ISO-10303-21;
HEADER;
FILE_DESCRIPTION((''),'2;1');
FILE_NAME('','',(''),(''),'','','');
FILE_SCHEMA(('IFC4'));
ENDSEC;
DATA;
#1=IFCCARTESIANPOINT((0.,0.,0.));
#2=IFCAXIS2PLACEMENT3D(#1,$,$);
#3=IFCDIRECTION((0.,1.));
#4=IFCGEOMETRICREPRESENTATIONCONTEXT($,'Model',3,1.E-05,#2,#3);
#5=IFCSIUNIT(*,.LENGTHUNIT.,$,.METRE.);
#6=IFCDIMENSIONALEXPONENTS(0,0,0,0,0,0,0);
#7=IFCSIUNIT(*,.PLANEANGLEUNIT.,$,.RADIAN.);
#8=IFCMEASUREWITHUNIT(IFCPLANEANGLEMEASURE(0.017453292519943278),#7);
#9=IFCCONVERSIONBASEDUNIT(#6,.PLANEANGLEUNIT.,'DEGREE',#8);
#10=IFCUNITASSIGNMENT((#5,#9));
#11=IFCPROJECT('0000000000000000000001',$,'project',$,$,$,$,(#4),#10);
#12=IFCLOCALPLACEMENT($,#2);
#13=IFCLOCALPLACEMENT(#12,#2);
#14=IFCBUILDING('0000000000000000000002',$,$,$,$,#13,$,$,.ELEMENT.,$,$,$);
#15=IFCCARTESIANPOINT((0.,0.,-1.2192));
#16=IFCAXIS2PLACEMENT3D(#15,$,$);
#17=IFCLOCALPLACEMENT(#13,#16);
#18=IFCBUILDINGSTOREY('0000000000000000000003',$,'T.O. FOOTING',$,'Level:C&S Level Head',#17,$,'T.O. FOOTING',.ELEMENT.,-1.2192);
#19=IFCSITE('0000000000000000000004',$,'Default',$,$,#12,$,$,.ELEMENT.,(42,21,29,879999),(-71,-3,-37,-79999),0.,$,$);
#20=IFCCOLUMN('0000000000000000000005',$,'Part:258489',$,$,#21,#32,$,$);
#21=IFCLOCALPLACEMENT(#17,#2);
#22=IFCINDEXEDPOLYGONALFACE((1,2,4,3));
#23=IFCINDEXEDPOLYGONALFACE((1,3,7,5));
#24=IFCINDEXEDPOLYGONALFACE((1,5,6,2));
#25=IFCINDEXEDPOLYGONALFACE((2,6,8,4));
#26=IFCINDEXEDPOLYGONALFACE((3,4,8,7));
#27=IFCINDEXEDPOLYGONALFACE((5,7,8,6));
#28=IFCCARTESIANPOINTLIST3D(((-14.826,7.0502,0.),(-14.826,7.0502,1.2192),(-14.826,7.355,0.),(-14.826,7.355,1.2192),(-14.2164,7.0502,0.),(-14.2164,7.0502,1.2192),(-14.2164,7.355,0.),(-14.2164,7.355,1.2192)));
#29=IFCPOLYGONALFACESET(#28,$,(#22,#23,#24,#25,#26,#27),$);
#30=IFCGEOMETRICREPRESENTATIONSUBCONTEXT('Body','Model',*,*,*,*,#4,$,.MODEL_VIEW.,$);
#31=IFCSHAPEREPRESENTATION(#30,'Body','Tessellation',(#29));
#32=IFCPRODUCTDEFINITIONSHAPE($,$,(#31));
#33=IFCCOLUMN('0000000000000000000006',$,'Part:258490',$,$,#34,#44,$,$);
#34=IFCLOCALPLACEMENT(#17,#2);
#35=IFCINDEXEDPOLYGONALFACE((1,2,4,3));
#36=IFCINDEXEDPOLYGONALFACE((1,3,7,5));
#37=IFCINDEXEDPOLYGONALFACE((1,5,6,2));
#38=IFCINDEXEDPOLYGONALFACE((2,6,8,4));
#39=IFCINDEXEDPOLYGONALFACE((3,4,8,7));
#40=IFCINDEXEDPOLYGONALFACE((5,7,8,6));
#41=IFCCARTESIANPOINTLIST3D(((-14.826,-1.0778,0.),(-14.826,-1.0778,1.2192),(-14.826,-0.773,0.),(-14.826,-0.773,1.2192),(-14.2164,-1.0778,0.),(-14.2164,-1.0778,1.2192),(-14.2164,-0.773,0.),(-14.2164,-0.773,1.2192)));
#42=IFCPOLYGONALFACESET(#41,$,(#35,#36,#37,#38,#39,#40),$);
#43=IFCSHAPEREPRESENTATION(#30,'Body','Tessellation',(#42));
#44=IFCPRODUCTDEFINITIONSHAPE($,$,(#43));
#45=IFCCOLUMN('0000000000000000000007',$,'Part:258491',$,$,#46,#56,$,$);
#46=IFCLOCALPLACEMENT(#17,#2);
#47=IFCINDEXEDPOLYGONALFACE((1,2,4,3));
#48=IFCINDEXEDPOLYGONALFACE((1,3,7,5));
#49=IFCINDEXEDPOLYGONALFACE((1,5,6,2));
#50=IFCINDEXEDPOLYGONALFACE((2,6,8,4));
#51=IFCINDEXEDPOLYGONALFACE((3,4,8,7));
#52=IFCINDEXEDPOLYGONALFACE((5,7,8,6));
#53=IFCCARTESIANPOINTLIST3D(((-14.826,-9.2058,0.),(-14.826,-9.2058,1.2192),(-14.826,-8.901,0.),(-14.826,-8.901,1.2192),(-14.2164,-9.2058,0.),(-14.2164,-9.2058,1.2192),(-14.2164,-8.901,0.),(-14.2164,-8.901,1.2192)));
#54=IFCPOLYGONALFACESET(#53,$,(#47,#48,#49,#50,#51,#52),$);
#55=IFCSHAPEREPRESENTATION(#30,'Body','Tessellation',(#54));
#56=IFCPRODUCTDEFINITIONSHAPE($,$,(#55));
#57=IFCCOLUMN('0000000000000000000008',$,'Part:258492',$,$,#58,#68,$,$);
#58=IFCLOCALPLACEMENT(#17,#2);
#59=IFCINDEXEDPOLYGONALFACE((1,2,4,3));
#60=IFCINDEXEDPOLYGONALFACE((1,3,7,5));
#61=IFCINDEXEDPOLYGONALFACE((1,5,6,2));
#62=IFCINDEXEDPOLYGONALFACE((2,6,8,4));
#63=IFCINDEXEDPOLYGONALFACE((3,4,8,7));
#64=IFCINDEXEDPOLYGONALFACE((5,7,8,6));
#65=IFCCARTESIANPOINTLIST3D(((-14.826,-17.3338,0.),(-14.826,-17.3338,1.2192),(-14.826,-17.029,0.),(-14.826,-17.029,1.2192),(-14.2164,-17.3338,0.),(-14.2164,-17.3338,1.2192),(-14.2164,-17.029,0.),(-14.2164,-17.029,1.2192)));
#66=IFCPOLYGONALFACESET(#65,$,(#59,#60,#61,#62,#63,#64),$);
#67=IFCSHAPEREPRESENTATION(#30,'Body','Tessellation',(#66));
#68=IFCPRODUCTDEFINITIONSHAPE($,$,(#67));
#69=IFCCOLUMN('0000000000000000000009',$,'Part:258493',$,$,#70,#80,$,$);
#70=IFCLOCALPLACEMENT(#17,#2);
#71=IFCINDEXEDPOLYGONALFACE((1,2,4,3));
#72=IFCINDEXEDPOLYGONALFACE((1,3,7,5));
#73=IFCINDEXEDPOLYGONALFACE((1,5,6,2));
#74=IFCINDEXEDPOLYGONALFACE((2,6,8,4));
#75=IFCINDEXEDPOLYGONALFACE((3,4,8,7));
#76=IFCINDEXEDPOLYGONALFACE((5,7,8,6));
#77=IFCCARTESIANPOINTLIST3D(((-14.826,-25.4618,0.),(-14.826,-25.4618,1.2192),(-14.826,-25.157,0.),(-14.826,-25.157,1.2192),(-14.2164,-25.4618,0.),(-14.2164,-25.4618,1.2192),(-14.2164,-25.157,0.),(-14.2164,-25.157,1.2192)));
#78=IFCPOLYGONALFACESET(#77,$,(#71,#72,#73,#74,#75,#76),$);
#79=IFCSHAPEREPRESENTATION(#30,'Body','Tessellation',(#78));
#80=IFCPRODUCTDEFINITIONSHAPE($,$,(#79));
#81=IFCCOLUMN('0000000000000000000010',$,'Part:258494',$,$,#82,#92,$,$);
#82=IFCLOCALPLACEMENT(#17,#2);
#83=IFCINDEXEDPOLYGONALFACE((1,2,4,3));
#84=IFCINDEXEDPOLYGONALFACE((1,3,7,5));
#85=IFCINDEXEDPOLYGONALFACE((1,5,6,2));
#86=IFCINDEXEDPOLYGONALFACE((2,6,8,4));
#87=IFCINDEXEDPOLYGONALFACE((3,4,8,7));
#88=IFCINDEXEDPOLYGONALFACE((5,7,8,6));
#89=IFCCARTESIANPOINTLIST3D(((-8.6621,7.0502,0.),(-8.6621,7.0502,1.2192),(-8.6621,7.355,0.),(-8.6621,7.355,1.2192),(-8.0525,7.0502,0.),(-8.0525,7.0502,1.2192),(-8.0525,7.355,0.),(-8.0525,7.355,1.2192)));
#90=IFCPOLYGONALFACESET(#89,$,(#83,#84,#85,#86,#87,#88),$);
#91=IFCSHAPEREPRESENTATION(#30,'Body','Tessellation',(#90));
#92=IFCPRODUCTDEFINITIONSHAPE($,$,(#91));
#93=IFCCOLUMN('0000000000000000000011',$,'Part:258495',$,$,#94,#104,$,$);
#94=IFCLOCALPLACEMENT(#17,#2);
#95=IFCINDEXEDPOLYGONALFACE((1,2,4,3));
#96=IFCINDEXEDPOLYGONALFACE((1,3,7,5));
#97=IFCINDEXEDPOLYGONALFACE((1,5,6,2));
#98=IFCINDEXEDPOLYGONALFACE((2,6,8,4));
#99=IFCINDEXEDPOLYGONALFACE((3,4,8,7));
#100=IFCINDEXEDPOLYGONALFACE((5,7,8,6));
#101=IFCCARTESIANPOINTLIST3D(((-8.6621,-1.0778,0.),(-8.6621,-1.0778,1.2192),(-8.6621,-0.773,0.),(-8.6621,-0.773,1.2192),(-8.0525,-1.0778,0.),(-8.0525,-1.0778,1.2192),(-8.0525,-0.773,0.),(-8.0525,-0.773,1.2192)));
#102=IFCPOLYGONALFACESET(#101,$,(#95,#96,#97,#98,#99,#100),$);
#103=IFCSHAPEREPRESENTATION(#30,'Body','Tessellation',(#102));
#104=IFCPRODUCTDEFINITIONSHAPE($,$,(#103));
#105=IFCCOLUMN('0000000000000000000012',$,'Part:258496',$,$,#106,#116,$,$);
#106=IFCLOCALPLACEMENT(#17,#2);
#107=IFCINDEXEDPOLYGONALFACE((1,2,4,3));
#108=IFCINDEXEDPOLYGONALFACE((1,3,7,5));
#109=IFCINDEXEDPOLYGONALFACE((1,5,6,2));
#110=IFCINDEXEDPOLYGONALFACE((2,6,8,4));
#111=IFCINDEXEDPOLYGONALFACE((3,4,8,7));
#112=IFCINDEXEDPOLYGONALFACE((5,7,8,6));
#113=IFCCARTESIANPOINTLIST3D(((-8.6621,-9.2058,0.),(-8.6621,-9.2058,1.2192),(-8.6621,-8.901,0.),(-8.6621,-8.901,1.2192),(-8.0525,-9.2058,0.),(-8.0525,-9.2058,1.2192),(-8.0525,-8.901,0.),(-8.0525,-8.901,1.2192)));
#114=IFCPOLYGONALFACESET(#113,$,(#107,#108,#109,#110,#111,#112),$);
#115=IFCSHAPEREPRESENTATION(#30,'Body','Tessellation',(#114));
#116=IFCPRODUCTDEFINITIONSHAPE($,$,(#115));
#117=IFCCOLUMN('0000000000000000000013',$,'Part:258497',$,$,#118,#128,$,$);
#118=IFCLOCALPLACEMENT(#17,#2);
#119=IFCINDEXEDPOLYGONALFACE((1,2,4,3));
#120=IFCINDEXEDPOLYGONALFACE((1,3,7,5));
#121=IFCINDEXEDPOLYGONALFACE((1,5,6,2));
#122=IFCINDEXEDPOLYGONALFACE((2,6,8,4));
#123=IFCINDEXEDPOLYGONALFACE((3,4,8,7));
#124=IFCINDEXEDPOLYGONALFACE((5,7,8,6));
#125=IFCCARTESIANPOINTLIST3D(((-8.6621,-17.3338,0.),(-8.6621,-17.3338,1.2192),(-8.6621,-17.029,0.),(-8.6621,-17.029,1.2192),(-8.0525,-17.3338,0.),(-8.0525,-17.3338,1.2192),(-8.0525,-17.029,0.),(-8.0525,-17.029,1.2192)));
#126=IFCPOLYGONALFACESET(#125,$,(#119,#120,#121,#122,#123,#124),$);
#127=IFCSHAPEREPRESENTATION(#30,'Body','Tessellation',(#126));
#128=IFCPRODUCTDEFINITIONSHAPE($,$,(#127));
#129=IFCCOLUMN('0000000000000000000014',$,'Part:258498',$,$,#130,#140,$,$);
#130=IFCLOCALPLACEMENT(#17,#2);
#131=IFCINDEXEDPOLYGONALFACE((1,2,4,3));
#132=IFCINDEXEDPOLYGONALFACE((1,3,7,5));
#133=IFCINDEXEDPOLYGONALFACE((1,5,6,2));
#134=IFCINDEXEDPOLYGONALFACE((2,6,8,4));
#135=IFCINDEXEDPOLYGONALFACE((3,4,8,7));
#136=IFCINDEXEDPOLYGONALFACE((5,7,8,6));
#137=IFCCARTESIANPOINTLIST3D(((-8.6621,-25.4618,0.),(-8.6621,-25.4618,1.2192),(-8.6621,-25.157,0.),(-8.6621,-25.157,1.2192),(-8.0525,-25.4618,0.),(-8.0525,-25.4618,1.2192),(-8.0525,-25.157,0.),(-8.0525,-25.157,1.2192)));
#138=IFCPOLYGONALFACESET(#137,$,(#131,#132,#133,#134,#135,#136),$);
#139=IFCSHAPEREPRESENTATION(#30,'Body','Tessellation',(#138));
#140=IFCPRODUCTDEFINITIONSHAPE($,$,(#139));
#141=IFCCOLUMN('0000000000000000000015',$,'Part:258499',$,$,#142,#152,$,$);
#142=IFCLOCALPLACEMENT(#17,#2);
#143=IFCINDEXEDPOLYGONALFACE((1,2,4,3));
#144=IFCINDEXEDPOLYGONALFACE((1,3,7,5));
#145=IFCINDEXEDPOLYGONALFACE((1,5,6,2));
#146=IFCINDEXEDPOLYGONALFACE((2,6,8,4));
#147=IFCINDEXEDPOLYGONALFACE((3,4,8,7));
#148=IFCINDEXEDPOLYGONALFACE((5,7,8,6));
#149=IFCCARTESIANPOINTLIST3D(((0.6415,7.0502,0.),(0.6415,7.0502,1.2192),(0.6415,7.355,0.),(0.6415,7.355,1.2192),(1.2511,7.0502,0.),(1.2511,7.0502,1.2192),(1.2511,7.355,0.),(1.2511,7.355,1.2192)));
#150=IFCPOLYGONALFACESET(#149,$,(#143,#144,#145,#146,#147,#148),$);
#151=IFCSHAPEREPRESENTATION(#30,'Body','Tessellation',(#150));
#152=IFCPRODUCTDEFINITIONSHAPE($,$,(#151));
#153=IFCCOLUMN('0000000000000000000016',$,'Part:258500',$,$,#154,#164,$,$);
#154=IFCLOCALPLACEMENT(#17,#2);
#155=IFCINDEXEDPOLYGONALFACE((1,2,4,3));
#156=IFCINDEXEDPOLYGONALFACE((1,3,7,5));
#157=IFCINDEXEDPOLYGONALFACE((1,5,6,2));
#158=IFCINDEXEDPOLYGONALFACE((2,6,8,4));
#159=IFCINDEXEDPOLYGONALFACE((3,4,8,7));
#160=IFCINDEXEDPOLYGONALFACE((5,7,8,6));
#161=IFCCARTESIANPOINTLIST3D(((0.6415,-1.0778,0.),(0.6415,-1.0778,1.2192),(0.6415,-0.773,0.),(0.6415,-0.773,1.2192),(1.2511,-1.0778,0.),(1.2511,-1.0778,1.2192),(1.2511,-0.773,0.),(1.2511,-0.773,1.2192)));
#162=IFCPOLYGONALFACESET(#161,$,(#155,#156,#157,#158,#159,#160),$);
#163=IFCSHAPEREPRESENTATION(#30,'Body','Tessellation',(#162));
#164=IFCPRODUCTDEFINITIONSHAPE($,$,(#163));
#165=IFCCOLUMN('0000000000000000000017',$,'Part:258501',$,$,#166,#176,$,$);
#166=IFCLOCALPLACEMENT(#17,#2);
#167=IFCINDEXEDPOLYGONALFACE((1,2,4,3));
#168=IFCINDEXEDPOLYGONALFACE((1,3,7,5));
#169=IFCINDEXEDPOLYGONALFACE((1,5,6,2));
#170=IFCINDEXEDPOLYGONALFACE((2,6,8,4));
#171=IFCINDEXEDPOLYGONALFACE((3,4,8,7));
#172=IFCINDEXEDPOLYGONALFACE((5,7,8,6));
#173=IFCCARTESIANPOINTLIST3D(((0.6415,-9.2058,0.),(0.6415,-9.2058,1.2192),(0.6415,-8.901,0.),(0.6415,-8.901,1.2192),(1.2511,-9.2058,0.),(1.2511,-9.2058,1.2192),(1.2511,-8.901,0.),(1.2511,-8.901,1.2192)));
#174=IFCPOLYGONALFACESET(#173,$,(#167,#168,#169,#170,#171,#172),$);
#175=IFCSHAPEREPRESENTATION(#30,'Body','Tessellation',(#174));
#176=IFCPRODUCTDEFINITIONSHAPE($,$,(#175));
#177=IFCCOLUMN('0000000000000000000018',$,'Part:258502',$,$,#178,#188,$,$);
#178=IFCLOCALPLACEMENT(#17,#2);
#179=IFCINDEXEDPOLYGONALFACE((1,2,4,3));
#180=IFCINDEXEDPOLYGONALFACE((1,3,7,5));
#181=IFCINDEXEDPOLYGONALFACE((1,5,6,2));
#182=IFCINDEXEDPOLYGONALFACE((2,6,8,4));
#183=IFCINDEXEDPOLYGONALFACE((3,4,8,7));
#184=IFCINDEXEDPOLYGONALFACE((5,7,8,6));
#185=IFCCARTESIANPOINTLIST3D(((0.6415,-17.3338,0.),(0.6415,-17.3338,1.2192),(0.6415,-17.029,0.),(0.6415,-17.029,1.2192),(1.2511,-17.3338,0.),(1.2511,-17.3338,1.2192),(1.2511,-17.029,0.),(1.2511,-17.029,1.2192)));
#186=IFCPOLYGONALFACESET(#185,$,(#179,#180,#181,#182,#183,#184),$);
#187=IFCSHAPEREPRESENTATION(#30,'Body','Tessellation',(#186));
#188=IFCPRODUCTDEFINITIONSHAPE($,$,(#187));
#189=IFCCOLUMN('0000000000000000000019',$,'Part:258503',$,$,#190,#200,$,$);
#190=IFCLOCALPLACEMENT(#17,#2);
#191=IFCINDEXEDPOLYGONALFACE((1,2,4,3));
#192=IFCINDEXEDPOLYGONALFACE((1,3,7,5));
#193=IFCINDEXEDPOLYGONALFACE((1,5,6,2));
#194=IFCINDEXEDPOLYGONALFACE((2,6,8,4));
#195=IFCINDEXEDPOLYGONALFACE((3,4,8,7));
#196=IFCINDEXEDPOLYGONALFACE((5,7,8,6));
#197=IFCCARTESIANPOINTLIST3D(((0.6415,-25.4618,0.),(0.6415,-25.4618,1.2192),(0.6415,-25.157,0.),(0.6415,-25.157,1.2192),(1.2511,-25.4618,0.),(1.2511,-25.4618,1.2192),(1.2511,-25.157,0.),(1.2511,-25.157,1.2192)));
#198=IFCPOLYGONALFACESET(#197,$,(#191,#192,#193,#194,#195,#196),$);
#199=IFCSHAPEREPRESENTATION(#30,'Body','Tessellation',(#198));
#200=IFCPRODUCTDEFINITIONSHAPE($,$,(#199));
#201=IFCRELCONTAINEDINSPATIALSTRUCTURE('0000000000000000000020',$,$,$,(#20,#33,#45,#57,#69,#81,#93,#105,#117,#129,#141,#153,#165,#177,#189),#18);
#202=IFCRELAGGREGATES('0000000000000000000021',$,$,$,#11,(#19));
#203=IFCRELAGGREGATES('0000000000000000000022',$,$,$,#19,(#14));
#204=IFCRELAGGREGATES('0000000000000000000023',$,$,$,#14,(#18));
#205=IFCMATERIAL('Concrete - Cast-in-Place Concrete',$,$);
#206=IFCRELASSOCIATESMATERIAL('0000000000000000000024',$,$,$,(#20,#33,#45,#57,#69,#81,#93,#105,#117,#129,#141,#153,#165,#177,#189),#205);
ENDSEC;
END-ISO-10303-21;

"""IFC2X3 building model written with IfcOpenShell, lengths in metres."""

from ifc_helpers import new_model, entity, si_unit, converted_unit, direction, frame, origin, origin_2d_with_axis, place, context, subcontext, project, spatial, rectangle, extrude, material, element, save


model = new_model("IFC2X3")

# Units and contexts
model_context = context("Model", 3, precision=1e-05, world=origin(), true_north=direction((0.0, 1.0)))
body_context = subcontext(model_context, "Body", "Model", "MODEL_VIEW")
ifc_project = project(units=[si_unit("LENGTHUNIT", "METRE"), converted_unit("PLANEANGLEUNIT", "DEGREE", entity("IfcPlaneAngleMeasure", 0.017453292519943278), si_unit("PLANEANGLEUNIT", "RADIAN"), dimensions=[0, 0, 0, 0, 0, 0, 0])], contexts=[model_context])

# Site, building, storey
site_placement = place(None, origin())
site = spatial("IfcSite", under=ifc_project, at=site_placement, Name="Default", CompositionType="ELEMENT", RefLatitude=(42, 21, 29, 879999), RefLongitude=(-71, -3, -37, -79999), RefElevation=0.0)
building_placement = place(site_placement, origin())
building = spatial("IfcBuilding", under=site, at=building_placement, CompositionType="ELEMENT")
storey_placement = place(building_placement, frame((0.0, 0.0, -1.2192)))
storey = spatial("IfcBuildingStorey", under=building, at=storey_placement, Name="T.O. FOOTING", ObjectType="Level:C&S Level Head", LongName="T.O. FOOTING", CompositionType="ELEMENT", Elevation=-1.2192)

# Columns
ifc_material = material(Name="Concrete - Cast-in-Place Concrete")
column_1_placement = place(storey_placement, origin())
element("IfcColumn", 1, at=column_1_placement, inside=storey, material=ifc_material, Name="Part:258489", context=body_context, shape_type="SweptSolid", body=[
    extrude(rectangle(XDim=1.2192, YDim=0.3048, at=origin_2d_with_axis()), frame((-14.826, 7.2026, 0.6096), z_axis=(1.0, 0.0, 0.0), x_axis=(0.0, 0.0, -1.0)), (0.0, 0.0, 1.0), 0.6096),
])
column_2_placement = place(storey_placement, origin())
element("IfcColumn", 2, at=column_2_placement, inside=storey, material=ifc_material, Name="Part:258490", context=body_context, shape_type="SweptSolid", body=[
    extrude(rectangle(XDim=1.2192, YDim=0.3048, at=origin_2d_with_axis()), frame((-14.826, -0.9254, 0.6096), z_axis=(1.0, 0.0, 0.0), x_axis=(0.0, 0.0, -1.0)), (0.0, 0.0, 1.0), 0.6096),
])
column_3_placement = place(storey_placement, origin())
element("IfcColumn", 3, at=column_3_placement, inside=storey, material=ifc_material, Name="Part:258491", context=body_context, shape_type="SweptSolid", body=[
    extrude(rectangle(XDim=1.2192, YDim=0.3048, at=origin_2d_with_axis()), frame((-14.826, -9.0534, 0.6096), z_axis=(1.0, 0.0, 0.0), x_axis=(0.0, 0.0, -1.0)), (0.0, 0.0, 1.0), 0.6096),
])
column_4_placement = place(storey_placement, origin())
element("IfcColumn", 4, at=column_4_placement, inside=storey, material=ifc_material, Name="Part:258492", context=body_context, shape_type="SweptSolid", body=[
    extrude(rectangle(XDim=1.2192, YDim=0.3048, at=origin_2d_with_axis()), frame((-14.826, -17.1814, 0.6096), z_axis=(1.0, 0.0, 0.0), x_axis=(0.0, 0.0, -1.0)), (0.0, 0.0, 1.0), 0.6096),
])
column_5_placement = place(storey_placement, origin())
element("IfcColumn", 5, at=column_5_placement, inside=storey, material=ifc_material, Name="Part:258493", context=body_context, shape_type="SweptSolid", body=[
    extrude(rectangle(XDim=1.2192, YDim=0.3048, at=origin_2d_with_axis()), frame((-14.826, -25.3094, 0.6096), z_axis=(1.0, 0.0, 0.0), x_axis=(0.0, 0.0, -1.0)), (0.0, 0.0, 1.0), 0.6096),
])
column_6_placement = place(storey_placement, origin())
element("IfcColumn", 6, at=column_6_placement, inside=storey, material=ifc_material, Name="Part:258494", context=body_context, shape_type="SweptSolid", body=[
    extrude(rectangle(XDim=1.2192, YDim=0.3048, at=origin_2d_with_axis()), frame((-8.6621, 7.2026, 0.6096), z_axis=(1.0, 0.0, 0.0), x_axis=(0.0, 0.0, -1.0)), (0.0, 0.0, 1.0), 0.6096),
])
column_7_placement = place(storey_placement, origin())
element("IfcColumn", 7, at=column_7_placement, inside=storey, material=ifc_material, Name="Part:258495", context=body_context, shape_type="SweptSolid", body=[
    extrude(rectangle(XDim=1.2192, YDim=0.3048, at=origin_2d_with_axis()), frame((-8.6621, -0.9254, 0.6096), z_axis=(1.0, 0.0, 0.0), x_axis=(0.0, 0.0, -1.0)), (0.0, 0.0, 1.0), 0.6096),
])
column_8_placement = place(storey_placement, origin())
element("IfcColumn", 8, at=column_8_placement, inside=storey, material=ifc_material, Name="Part:258496", context=body_context, shape_type="SweptSolid", body=[
    extrude(rectangle(XDim=1.2192, YDim=0.3048, at=origin_2d_with_axis()), frame((-8.6621, -9.0534, 0.6096), z_axis=(1.0, 0.0, 0.0), x_axis=(0.0, 0.0, -1.0)), (0.0, 0.0, 1.0), 0.6096),
])
column_9_placement = place(storey_placement, origin())
element("IfcColumn", 9, at=column_9_placement, inside=storey, material=ifc_material, Name="Part:258497", context=body_context, shape_type="SweptSolid", body=[
    extrude(rectangle(XDim=1.2192, YDim=0.3048, at=origin_2d_with_axis()), frame((-8.6621, -17.1814, 0.6096), z_axis=(1.0, 0.0, 0.0), x_axis=(0.0, 0.0, -1.0)), (0.0, 0.0, 1.0), 0.6096),
])
column_10_placement = place(storey_placement, origin())
element("IfcColumn", 10, at=column_10_placement, inside=storey, material=ifc_material, Name="Part:258498", context=body_context, shape_type="SweptSolid", body=[
    extrude(rectangle(XDim=1.2192, YDim=0.3048, at=origin_2d_with_axis()), frame((-8.6621, -25.3094, 0.6096), z_axis=(1.0, 0.0, 0.0), x_axis=(0.0, 0.0, -1.0)), (0.0, 0.0, 1.0), 0.6096),
])
column_11_placement = place(storey_placement, origin())
element("IfcColumn", 11, at=column_11_placement, inside=storey, material=ifc_material, Name="Part:258499", context=body_context, shape_type="SweptSolid", body=[
    extrude(rectangle(XDim=1.2192, YDim=0.3048, at=origin_2d_with_axis()), frame((0.6415, 7.2026, 0.6096), z_axis=(1.0, 0.0, 0.0), x_axis=(0.0, 0.0, -1.0)), (0.0, 0.0, 1.0), 0.6096),
])
column_12_placement = place(storey_placement, origin())
element("IfcColumn", 12, at=column_12_placement, inside=storey, material=ifc_material, Name="Part:258500", context=body_context, shape_type="SweptSolid", body=[
    extrude(rectangle(XDim=1.2192, YDim=0.3048, at=origin_2d_with_axis()), frame((0.6415, -0.9254, 0.6096), z_axis=(1.0, 0.0, 0.0), x_axis=(0.0, 0.0, -1.0)), (0.0, 0.0, 1.0), 0.6096),
])
column_13_placement = place(storey_placement, origin())
element("IfcColumn", 13, at=column_13_placement, inside=storey, material=ifc_material, Name="Part:258501", context=body_context, shape_type="SweptSolid", body=[
    extrude(rectangle(XDim=1.2192, YDim=0.3048, at=origin_2d_with_axis()), frame((0.6415, -9.0534, 0.6096), z_axis=(1.0, 0.0, 0.0), x_axis=(0.0, 0.0, -1.0)), (0.0, 0.0, 1.0), 0.6096),
])
column_14_placement = place(storey_placement, origin())
element("IfcColumn", 14, at=column_14_placement, inside=storey, material=ifc_material, Name="Part:258502", context=body_context, shape_type="SweptSolid", body=[
    extrude(rectangle(XDim=1.2192, YDim=0.3048, at=origin_2d_with_axis()), frame((0.6415, -17.1814, 0.6096), z_axis=(1.0, 0.0, 0.0), x_axis=(0.0, 0.0, -1.0)), (0.0, 0.0, 1.0), 0.6096),
])
column_15_placement = place(storey_placement, origin())
element("IfcColumn", 15, at=column_15_placement, inside=storey, material=ifc_material, Name="Part:258503", context=body_context, shape_type="SweptSolid", body=[
    extrude(rectangle(XDim=1.2192, YDim=0.3048, at=origin_2d_with_axis()), frame((0.6415, -25.3094, 0.6096), z_axis=(1.0, 0.0, 0.0), x_axis=(0.0, 0.0, -1.0)), (0.0, 0.0, 1.0), 0.6096),
])

save(model, "model.ifc")
